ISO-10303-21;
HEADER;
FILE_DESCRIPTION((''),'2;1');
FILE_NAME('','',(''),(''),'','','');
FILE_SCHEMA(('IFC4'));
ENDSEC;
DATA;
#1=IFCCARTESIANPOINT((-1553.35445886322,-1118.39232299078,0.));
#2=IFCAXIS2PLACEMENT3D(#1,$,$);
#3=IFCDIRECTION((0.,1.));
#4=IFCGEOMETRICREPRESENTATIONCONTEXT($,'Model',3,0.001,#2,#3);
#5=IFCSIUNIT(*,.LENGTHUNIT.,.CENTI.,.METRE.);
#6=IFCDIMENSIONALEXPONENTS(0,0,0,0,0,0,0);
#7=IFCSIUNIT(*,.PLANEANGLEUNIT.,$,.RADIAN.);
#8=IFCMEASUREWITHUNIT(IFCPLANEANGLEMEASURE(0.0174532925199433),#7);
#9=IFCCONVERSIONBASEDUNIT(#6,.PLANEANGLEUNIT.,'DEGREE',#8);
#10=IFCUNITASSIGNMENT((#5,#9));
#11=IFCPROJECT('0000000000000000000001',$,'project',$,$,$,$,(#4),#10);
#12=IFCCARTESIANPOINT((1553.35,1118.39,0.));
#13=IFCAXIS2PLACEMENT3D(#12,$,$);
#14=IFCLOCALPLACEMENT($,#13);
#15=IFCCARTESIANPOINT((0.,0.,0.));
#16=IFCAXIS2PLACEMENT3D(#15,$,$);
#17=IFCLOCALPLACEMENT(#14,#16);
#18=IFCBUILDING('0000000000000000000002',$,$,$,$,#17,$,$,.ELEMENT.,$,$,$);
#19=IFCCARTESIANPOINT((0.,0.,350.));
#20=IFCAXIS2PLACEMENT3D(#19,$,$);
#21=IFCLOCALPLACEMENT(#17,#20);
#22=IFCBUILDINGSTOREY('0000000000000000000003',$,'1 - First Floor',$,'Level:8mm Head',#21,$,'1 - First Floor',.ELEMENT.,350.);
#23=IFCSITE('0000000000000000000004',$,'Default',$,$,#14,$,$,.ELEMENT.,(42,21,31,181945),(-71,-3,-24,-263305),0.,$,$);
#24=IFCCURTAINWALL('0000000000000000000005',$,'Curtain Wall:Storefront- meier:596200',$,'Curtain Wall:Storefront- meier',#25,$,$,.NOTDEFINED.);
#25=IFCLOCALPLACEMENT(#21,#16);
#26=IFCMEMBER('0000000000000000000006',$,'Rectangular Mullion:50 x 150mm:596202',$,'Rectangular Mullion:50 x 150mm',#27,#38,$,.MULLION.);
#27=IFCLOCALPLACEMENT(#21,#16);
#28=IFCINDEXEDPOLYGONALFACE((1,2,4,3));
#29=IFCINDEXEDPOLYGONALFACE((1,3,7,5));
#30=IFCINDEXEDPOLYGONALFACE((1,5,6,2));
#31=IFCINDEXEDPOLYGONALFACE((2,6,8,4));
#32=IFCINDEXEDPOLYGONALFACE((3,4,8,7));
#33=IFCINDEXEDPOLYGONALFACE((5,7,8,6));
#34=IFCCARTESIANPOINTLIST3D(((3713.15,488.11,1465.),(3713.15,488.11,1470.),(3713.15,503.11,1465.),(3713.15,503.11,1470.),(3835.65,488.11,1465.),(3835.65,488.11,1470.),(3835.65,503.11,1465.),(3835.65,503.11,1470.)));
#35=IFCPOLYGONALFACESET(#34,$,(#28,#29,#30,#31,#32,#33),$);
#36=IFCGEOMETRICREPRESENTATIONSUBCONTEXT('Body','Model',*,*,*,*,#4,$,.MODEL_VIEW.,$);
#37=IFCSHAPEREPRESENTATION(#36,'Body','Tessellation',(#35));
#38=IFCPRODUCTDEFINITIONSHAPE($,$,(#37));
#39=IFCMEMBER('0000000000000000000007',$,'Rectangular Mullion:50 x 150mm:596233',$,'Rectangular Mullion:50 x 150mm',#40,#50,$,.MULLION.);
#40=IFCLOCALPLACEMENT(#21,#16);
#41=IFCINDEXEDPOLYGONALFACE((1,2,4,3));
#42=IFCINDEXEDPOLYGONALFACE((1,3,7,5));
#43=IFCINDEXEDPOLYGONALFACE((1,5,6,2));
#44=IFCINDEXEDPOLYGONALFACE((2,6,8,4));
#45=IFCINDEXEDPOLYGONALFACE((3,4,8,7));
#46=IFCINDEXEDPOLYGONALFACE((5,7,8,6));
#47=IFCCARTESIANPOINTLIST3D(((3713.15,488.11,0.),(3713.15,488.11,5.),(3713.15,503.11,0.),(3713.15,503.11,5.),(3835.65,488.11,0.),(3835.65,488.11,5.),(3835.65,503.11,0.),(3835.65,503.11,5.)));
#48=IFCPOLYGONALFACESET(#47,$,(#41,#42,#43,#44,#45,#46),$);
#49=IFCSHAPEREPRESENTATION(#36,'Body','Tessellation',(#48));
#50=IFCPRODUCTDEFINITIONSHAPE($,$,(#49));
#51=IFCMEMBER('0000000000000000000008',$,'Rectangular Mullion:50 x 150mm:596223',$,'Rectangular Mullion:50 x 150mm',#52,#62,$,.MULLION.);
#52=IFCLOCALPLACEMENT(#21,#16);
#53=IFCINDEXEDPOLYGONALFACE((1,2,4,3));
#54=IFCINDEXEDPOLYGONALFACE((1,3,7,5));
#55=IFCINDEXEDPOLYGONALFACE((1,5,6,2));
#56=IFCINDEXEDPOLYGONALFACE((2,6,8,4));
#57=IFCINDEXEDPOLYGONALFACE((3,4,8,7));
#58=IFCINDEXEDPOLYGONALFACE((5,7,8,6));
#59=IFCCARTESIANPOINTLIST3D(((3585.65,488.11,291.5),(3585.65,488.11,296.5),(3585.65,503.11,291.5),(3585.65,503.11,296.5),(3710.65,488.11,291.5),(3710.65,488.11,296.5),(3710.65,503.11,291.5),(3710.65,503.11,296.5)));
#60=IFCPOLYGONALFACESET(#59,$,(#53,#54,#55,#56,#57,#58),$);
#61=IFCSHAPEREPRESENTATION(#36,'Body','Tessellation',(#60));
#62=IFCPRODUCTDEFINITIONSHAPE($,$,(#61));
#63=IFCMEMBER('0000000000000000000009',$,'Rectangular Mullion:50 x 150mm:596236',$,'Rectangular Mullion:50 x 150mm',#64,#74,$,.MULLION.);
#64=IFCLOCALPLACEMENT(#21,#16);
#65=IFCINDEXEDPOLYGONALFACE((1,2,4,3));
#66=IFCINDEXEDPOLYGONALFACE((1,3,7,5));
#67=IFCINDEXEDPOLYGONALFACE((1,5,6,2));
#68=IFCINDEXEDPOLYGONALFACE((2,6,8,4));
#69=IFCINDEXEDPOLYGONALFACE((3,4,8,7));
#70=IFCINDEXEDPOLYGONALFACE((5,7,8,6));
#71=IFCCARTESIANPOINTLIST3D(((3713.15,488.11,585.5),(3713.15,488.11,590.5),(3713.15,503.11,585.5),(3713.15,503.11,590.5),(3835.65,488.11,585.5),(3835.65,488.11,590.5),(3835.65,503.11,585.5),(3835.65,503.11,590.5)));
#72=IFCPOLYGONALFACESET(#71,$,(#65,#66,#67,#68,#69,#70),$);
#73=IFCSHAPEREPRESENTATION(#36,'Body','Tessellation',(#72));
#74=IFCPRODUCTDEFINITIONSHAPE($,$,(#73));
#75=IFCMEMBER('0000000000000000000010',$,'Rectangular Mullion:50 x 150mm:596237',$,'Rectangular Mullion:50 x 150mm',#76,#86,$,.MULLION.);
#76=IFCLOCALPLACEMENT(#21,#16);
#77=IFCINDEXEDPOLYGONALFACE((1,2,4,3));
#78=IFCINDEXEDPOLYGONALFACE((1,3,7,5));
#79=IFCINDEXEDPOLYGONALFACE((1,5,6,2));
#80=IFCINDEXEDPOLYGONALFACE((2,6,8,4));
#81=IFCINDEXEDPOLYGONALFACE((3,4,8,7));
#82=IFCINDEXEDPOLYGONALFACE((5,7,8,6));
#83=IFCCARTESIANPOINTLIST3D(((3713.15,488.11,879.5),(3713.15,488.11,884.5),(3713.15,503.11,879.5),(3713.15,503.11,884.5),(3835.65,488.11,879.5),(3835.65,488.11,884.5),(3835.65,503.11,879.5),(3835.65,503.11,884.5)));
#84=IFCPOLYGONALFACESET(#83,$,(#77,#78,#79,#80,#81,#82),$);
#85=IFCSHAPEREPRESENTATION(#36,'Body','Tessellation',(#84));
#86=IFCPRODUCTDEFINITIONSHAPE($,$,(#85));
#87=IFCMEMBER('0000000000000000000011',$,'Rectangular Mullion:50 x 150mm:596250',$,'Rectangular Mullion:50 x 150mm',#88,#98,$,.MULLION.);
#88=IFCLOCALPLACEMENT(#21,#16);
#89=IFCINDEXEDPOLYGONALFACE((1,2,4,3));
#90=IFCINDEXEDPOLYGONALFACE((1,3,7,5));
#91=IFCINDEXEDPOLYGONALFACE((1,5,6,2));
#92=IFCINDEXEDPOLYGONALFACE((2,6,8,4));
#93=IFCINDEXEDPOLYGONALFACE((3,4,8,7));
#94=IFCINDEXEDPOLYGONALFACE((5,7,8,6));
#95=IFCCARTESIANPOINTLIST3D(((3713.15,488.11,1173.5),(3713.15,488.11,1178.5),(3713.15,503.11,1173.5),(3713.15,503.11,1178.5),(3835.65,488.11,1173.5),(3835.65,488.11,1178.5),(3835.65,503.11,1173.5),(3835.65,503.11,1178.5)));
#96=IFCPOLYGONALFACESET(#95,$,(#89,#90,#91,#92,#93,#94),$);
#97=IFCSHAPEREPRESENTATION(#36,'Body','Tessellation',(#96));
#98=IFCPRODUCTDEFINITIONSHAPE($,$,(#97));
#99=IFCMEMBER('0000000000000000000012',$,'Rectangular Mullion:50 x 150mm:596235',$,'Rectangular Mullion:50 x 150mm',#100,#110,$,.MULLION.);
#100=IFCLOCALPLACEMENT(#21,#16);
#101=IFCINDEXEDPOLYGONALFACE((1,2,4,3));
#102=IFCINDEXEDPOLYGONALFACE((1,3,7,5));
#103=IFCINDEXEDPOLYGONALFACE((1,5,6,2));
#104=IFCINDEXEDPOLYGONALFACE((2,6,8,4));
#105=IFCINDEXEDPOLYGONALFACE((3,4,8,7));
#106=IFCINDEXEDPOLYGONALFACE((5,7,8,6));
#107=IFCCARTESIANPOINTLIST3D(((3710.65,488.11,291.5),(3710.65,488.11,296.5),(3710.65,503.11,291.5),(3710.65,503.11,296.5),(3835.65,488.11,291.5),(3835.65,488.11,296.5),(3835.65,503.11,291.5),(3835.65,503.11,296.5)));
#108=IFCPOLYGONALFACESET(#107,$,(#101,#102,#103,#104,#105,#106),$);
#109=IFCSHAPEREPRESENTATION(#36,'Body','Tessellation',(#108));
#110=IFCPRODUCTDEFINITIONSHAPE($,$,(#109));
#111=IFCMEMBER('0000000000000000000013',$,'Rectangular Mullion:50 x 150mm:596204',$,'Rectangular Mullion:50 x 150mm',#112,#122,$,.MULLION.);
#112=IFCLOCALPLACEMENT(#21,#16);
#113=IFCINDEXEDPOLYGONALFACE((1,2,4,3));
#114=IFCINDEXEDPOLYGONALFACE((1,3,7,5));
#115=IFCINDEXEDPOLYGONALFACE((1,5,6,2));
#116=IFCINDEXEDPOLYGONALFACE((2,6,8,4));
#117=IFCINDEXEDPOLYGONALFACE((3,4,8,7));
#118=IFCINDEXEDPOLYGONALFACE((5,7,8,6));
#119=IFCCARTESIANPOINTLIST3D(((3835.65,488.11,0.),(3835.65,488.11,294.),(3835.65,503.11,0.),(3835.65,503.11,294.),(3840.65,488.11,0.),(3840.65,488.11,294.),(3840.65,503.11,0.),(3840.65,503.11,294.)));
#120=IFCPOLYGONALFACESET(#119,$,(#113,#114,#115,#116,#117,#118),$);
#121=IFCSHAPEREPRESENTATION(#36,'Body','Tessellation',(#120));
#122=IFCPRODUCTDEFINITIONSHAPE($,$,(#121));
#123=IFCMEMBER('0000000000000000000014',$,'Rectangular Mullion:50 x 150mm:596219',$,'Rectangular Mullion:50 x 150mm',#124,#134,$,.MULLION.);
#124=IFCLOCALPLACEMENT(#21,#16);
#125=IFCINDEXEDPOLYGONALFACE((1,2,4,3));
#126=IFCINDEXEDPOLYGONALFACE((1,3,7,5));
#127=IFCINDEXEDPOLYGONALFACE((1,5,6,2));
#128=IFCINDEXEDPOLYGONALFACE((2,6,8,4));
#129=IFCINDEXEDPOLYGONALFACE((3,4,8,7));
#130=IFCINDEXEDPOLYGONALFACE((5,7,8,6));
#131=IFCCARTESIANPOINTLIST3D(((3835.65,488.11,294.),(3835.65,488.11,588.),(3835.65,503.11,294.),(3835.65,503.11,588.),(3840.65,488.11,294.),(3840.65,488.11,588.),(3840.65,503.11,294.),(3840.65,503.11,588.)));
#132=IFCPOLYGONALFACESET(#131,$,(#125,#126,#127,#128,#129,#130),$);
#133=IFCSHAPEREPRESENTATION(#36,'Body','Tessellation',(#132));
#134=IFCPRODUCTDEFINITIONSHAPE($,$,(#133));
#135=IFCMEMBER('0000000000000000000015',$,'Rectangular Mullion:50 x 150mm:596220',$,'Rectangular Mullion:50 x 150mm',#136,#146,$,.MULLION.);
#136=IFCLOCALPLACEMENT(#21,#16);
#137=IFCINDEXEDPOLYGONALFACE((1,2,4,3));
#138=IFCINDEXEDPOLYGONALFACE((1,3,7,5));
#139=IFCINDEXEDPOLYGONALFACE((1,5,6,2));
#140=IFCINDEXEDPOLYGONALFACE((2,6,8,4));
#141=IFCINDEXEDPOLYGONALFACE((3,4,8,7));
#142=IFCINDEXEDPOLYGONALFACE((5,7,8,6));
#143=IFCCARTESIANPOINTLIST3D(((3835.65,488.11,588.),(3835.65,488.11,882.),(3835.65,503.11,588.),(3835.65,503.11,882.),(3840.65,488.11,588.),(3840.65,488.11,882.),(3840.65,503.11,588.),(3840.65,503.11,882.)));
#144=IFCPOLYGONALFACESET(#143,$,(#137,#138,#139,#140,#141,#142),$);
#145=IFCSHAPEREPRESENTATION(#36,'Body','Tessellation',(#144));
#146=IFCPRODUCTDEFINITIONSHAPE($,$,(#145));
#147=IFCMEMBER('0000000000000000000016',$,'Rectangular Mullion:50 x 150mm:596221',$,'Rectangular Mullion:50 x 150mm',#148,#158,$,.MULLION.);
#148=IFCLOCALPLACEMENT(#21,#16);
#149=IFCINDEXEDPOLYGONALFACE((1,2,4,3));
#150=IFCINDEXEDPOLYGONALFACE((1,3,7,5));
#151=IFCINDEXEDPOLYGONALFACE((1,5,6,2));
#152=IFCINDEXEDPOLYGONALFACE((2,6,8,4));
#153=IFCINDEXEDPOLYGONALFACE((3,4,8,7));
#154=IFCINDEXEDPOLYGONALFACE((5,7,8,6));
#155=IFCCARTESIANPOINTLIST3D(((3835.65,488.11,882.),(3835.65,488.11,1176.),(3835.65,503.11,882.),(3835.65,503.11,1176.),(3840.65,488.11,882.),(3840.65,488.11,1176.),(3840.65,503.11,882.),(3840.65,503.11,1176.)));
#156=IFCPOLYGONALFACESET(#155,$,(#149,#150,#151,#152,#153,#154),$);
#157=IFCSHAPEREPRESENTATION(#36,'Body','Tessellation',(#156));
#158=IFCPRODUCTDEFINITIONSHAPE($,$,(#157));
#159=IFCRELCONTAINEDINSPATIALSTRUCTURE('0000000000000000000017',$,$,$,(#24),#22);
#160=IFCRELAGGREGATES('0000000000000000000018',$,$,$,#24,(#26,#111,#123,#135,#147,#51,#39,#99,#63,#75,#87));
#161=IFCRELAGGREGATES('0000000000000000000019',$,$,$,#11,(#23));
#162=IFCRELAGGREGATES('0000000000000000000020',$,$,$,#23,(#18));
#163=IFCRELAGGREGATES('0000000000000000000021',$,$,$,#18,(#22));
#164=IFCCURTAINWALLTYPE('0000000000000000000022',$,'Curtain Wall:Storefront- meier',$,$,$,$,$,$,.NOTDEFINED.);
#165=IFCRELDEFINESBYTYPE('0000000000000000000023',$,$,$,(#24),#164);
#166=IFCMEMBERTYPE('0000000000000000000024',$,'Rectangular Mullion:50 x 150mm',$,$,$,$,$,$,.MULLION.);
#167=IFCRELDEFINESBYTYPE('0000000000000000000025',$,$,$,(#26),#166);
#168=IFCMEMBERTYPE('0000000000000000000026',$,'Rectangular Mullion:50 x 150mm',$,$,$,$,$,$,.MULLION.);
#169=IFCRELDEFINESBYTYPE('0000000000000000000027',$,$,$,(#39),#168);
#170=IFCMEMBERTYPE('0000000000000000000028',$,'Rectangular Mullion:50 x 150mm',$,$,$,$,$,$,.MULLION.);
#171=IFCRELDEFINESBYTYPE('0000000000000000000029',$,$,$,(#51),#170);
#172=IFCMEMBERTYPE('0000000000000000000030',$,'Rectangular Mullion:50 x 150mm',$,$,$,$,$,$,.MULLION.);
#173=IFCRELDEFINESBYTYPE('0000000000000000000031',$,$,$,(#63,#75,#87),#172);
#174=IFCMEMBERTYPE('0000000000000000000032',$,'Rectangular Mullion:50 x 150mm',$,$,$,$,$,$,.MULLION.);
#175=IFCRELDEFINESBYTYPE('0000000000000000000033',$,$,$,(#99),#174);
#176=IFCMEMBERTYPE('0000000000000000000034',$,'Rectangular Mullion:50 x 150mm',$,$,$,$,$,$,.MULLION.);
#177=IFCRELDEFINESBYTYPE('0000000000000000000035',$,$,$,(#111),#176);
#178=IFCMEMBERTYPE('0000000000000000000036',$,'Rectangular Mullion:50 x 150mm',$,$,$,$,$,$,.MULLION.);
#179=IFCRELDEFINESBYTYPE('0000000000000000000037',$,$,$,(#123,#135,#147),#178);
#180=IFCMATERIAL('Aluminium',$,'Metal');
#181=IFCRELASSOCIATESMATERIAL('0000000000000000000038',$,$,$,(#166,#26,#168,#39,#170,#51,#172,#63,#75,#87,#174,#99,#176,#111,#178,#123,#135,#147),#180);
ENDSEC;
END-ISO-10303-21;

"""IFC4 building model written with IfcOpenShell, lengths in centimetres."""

from ifc_helpers import new_model, entity, si_unit, converted_unit, direction, frame, origin, place, context, subcontext, project, spatial, indexed_curve, outline, extrude, source, transform, mapped, material, type_object, type_shapes, element, aggregate, save


model = new_model("IFC4")

# Units and contexts
model_context = context("Model", 3, precision=0.001, world=frame((-1553.35445886322, -1118.39232299078, 0.0)), true_north=direction((0.0, 1.0)))
body_context = subcontext(model_context, "Body", "Model", "MODEL_VIEW")
ifc_project = project(units=[si_unit("LENGTHUNIT", "METRE", prefix="CENTI"), converted_unit("PLANEANGLEUNIT", "DEGREE", entity("IfcPlaneAngleMeasure", 0.0174532925199433), si_unit("PLANEANGLEUNIT", "RADIAN"), dimensions=[0, 0, 0, 0, 0, 0, 0])], contexts=[model_context])

# Site, building, storey
site_placement = place(None, frame((1553.35, 1118.39, 0.0)))
site = spatial("IfcSite", under=ifc_project, at=site_placement, Name="Default", CompositionType="ELEMENT", RefLatitude=(42, 21, 31, 181945), RefLongitude=(-71, -3, -24, -263305), RefElevation=0.0)
building_placement = place(site_placement, origin())
building = spatial("IfcBuilding", under=site, at=building_placement, CompositionType="ELEMENT")
storey_placement = place(building_placement, frame((0.0, 0.0, 350.0)))
storey = spatial("IfcBuildingStorey", under=building, at=storey_placement, Name="1 - First Floor", ObjectType="Level:8mm Head", LongName="1 - First Floor", CompositionType="ELEMENT", Elevation=350.0)

# Curtain wall, members
curtain_wall_type = type_object("IfcCurtainWallType", Name="Curtain Wall:Storefront- meier", PredefinedType="NOTDEFINED")
curtain_wall_placement = place(storey_placement, frame((0.0, 0.0, -350.0)))
curtain_wall = element("IfcCurtainWall", 1, at=curtain_wall_placement, inside=storey, type_object=curtain_wall_type, Name="Curtain Wall:Storefront- meier:596200", ObjectType="Curtain Wall:Storefront- meier", PredefinedType="NOTDEFINED")
ifc_material_1 = material(Name="Aluminium", Category="Metal")
member_type_1 = type_object("IfcMemberType", Name="Rectangular Mullion:50 x 150mm", PredefinedType="MULLION", material=ifc_material_1)
shared_shape_1 = source(origin(), body_context, "Body", "SweptSolid", [
    extrude(outline(indexed_curve([(-2.5, -7.5), (2.5, -7.5), (2.5, 7.5), (-2.5, 7.5), (-2.5, -7.5)], self_intersect=False)), frame((-2.5, 0.0, -122.5), z_axis=(0.0, 0.0, 1.0), x_axis=(-1.0, 0.0, 0.0)), (0.0, 0.0, 1.0), 122.5),
])
type_shapes(member_type_1, [shared_shape_1])
member_1_placement = place(curtain_wall_placement, frame((3835.65, 495.61, 1820.0), z_axis=(1.0, 0.0, 0.0), x_axis=(0.0, 0.0, 1.0)))
member_1 = element("IfcMember", 2, at=member_1_placement, type_object=member_type_1, material=ifc_material_1, Name="Rectangular Mullion:50 x 150mm:596202", ObjectType="Rectangular Mullion:50 x 150mm", PredefinedType="MULLION", context=body_context, shape_type="MappedRepresentation", body=[
    mapped(shared_shape_1, transform((0.0, 0.0, 0.0), scale=1.0)),
])
member_type_2 = type_object("IfcMemberType", Name="Rectangular Mullion:50 x 150mm", PredefinedType="MULLION", material=ifc_material_1)
shared_shape_2 = source(origin(), body_context, "Body", "SweptSolid", [
    extrude(outline(indexed_curve([(-2.5, -7.5), (2.5, -7.5), (2.5, 7.5), (-2.5, 7.5), (-2.5, -7.5)], self_intersect=False)), frame((-2.5, 0.0, -122.5), z_axis=(0.0, 0.0, 1.0), x_axis=(-1.0, 0.0, 0.0)), (0.0, 0.0, 1.0), 122.5),
])
type_shapes(member_type_2, [shared_shape_2])
member_2_placement = place(curtain_wall_placement, frame((3713.15, 495.61, 350.0), z_axis=(-1.0, 0.0, 0.0), x_axis=(0.0, 0.0, -1.0)))
member_2 = element("IfcMember", 3, at=member_2_placement, type_object=member_type_2, material=ifc_material_1, Name="Rectangular Mullion:50 x 150mm:596233", ObjectType="Rectangular Mullion:50 x 150mm", PredefinedType="MULLION", context=body_context, shape_type="MappedRepresentation", body=[
    mapped(shared_shape_2, transform((0.0, 0.0, 0.0), scale=1.0)),
])
member_type_3 = type_object("IfcMemberType", Name="Rectangular Mullion:50 x 150mm", PredefinedType="MULLION", material=ifc_material_1)
shared_shape_3 = source(origin(), body_context, "Body", "SweptSolid", [
    extrude(outline(indexed_curve([(-2.5, -7.5), (2.5, -7.5), (2.5, 7.5), (-2.5, 7.5), (-2.5, -7.5)], self_intersect=False)), frame((0.0, 0.0, -125.0), z_axis=(0.0, 0.0, 1.0), x_axis=(-1.0, 0.0, 0.0)), (0.0, 0.0, 1.0), 125.0),
])
type_shapes(member_type_3, [shared_shape_3])
member_3_placement = place(curtain_wall_placement, frame((3710.65, 495.61, 644.0), z_axis=(1.0, 0.0, 0.0), x_axis=(0.0, 0.0, 1.0)))
member_3 = element("IfcMember", 4, at=member_3_placement, type_object=member_type_3, material=ifc_material_1, Name="Rectangular Mullion:50 x 150mm:596223", ObjectType="Rectangular Mullion:50 x 150mm", PredefinedType="MULLION", context=body_context, shape_type="MappedRepresentation", body=[
    mapped(shared_shape_3, transform((0.0, 0.0, 0.0), scale=1.0)),
])
member_type_4 = type_object("IfcMemberType", Name="Rectangular Mullion:50 x 150mm", PredefinedType="MULLION", material=ifc_material_1)
shared_shape_4 = source(origin(), body_context, "Body", "SweptSolid", [
    extrude(outline(indexed_curve([(-2.5, -7.5), (2.5, -7.5), (2.5, 7.5), (-2.5, 7.5), (-2.5, -7.5)], self_intersect=False)), frame((0.0, 0.0, -122.5), z_axis=(0.0, 0.0, 1.0), x_axis=(-1.0, 0.0, 0.0)), (0.0, 0.0, 1.0), 122.5),
])
type_shapes(member_type_4, [shared_shape_4])
member_4_placement = place(curtain_wall_placement, frame((3835.65, 495.61, 938.0), z_axis=(1.0, 0.0, 0.0), x_axis=(0.0, 0.0, 1.0)))
member_4 = element("IfcMember", 5, at=member_4_placement, type_object=member_type_4, material=ifc_material_1, Name="Rectangular Mullion:50 x 150mm:596236", ObjectType="Rectangular Mullion:50 x 150mm", PredefinedType="MULLION", context=body_context, shape_type="MappedRepresentation", body=[
    mapped(shared_shape_4, transform((0.0, 0.0, 0.0), scale=1.0)),
])
member_5_placement = place(curtain_wall_placement, frame((3835.65, 495.61, 1232.0), z_axis=(1.0, 0.0, 0.0), x_axis=(0.0, 0.0, 1.0)))
member_5 = element("IfcMember", 6, at=member_5_placement, type_object=member_type_4, material=ifc_material_1, Name="Rectangular Mullion:50 x 150mm:596237", ObjectType="Rectangular Mullion:50 x 150mm", PredefinedType="MULLION", context=body_context, shape_type="MappedRepresentation", body=[
    mapped(shared_shape_4, transform((0.0, 0.0, 0.0), scale=1.0)),
])
member_6_placement = place(curtain_wall_placement, frame((3835.65, 495.61, 1526.0), z_axis=(1.0, 0.0, 0.0), x_axis=(0.0, 0.0, 1.0)))
member_6 = element("IfcMember", 7, at=member_6_placement, type_object=member_type_4, material=ifc_material_1, Name="Rectangular Mullion:50 x 150mm:596250", ObjectType="Rectangular Mullion:50 x 150mm", PredefinedType="MULLION", context=body_context, shape_type="MappedRepresentation", body=[
    mapped(shared_shape_4, transform((0.0, 0.0, 0.0), scale=1.0)),
])
member_type_5 = type_object("IfcMemberType", Name="Rectangular Mullion:50 x 150mm", PredefinedType="MULLION", material=ifc_material_1)
shared_shape_5 = source(origin(), body_context, "Body", "SweptSolid", [
    extrude(outline(indexed_curve([(-2.5, -7.5), (2.5, -7.5), (2.5, 7.5), (-2.5, 7.5), (-2.5, -7.5)], self_intersect=False)), frame((0.0, 0.0, -125.0), z_axis=(0.0, 0.0, 1.0), x_axis=(-1.0, 0.0, 0.0)), (0.0, 0.0, 1.0), 125.0),
])
type_shapes(member_type_5, [shared_shape_5])
member_7_placement = place(curtain_wall_placement, frame((3835.65, 495.61, 644.0), z_axis=(1.0, 0.0, 0.0), x_axis=(0.0, 0.0, 1.0)))
member_7 = element("IfcMember", 8, at=member_7_placement, type_object=member_type_5, material=ifc_material_1, Name="Rectangular Mullion:50 x 150mm:596235", ObjectType="Rectangular Mullion:50 x 150mm", PredefinedType="MULLION", context=body_context, shape_type="MappedRepresentation", body=[
    mapped(shared_shape_5, transform((0.0, 0.0, 0.0), scale=1.0)),
])
member_type_6 = type_object("IfcMemberType", Name="Rectangular Mullion:50 x 150mm", PredefinedType="MULLION", material=ifc_material_1)
shared_shape_6 = source(origin(), body_context, "Body", "SweptSolid", [
    extrude(outline(indexed_curve([(-2.5, -7.5), (2.5, -7.5), (2.5, 7.5), (-2.5, 7.5), (-2.5, -7.5)], self_intersect=False)), frame((-2.5, 0.0, -294.0), z_axis=(0.0, 0.0, 1.0), x_axis=(-1.0, 0.0, 0.0)), (0.0, 0.0, 1.0), 294.0),
])
type_shapes(member_type_6, [shared_shape_6])
member_8_placement = place(curtain_wall_placement, frame((3840.65, 495.61, 350.0), z_axis=(0.0, 0.0, -1.0), x_axis=(1.0, 0.0, 0.0)))
member_8 = element("IfcMember", 9, at=member_8_placement, type_object=member_type_6, material=ifc_material_1, Name="Rectangular Mullion:50 x 150mm:596204", ObjectType="Rectangular Mullion:50 x 150mm", PredefinedType="MULLION", context=body_context, shape_type="MappedRepresentation", body=[
    mapped(shared_shape_6, transform((0.0, 0.0, 0.0), scale=1.0)),
])
member_type_7 = type_object("IfcMemberType", Name="Rectangular Mullion:50 x 150mm", PredefinedType="MULLION", material=ifc_material_1)
shared_shape_7 = source(origin(), body_context, "Body", "SweptSolid", [
    extrude(outline(indexed_curve([(-2.5, -7.5), (2.5, -7.5), (2.5, 7.5), (-2.5, 7.5), (-2.5, -7.5)], self_intersect=False)), frame((-2.5, 0.0, -294.0), z_axis=(0.0, 0.0, 1.0), x_axis=(-1.0, 0.0, 0.0)), (0.0, 0.0, 1.0), 294.0),
])
type_shapes(member_type_7, [shared_shape_7])
member_9_placement = place(curtain_wall_placement, frame((3840.65, 495.61, 644.0), z_axis=(0.0, 0.0, -1.0), x_axis=(1.0, 0.0, 0.0)))
member_9 = element("IfcMember", 10, at=member_9_placement, type_object=member_type_7, material=ifc_material_1, Name="Rectangular Mullion:50 x 150mm:596219", ObjectType="Rectangular Mullion:50 x 150mm", PredefinedType="MULLION", context=body_context, shape_type="MappedRepresentation", body=[
    mapped(shared_shape_7, transform((0.0, 0.0, 0.0), scale=1.0)),
])
member_10_placement = place(curtain_wall_placement, frame((3840.65, 495.61, 938.0), z_axis=(0.0, 0.0, -1.0), x_axis=(1.0, 0.0, 0.0)))
member_10 = element("IfcMember", 11, at=member_10_placement, type_object=member_type_7, material=ifc_material_1, Name="Rectangular Mullion:50 x 150mm:596220", ObjectType="Rectangular Mullion:50 x 150mm", PredefinedType="MULLION", context=body_context, shape_type="MappedRepresentation", body=[
    mapped(shared_shape_7, transform((0.0, 0.0, 0.0), scale=1.0)),
])
member_11_placement = place(curtain_wall_placement, frame((3840.65, 495.61, 1232.0), z_axis=(0.0, 0.0, -1.0), x_axis=(1.0, 0.0, 0.0)))
member_11 = element("IfcMember", 12, at=member_11_placement, type_object=member_type_7, material=ifc_material_1, Name="Rectangular Mullion:50 x 150mm:596221", ObjectType="Rectangular Mullion:50 x 150mm", PredefinedType="MULLION", context=body_context, shape_type="MappedRepresentation", body=[
    mapped(shared_shape_7, transform((0.0, 0.0, 0.0), scale=1.0)),
])
aggregate(curtain_wall, [member_1, member_8, member_9, member_10, member_11, member_3, member_2, member_7, member_4, member_5, member_6])

save(model, "model.ifc")
